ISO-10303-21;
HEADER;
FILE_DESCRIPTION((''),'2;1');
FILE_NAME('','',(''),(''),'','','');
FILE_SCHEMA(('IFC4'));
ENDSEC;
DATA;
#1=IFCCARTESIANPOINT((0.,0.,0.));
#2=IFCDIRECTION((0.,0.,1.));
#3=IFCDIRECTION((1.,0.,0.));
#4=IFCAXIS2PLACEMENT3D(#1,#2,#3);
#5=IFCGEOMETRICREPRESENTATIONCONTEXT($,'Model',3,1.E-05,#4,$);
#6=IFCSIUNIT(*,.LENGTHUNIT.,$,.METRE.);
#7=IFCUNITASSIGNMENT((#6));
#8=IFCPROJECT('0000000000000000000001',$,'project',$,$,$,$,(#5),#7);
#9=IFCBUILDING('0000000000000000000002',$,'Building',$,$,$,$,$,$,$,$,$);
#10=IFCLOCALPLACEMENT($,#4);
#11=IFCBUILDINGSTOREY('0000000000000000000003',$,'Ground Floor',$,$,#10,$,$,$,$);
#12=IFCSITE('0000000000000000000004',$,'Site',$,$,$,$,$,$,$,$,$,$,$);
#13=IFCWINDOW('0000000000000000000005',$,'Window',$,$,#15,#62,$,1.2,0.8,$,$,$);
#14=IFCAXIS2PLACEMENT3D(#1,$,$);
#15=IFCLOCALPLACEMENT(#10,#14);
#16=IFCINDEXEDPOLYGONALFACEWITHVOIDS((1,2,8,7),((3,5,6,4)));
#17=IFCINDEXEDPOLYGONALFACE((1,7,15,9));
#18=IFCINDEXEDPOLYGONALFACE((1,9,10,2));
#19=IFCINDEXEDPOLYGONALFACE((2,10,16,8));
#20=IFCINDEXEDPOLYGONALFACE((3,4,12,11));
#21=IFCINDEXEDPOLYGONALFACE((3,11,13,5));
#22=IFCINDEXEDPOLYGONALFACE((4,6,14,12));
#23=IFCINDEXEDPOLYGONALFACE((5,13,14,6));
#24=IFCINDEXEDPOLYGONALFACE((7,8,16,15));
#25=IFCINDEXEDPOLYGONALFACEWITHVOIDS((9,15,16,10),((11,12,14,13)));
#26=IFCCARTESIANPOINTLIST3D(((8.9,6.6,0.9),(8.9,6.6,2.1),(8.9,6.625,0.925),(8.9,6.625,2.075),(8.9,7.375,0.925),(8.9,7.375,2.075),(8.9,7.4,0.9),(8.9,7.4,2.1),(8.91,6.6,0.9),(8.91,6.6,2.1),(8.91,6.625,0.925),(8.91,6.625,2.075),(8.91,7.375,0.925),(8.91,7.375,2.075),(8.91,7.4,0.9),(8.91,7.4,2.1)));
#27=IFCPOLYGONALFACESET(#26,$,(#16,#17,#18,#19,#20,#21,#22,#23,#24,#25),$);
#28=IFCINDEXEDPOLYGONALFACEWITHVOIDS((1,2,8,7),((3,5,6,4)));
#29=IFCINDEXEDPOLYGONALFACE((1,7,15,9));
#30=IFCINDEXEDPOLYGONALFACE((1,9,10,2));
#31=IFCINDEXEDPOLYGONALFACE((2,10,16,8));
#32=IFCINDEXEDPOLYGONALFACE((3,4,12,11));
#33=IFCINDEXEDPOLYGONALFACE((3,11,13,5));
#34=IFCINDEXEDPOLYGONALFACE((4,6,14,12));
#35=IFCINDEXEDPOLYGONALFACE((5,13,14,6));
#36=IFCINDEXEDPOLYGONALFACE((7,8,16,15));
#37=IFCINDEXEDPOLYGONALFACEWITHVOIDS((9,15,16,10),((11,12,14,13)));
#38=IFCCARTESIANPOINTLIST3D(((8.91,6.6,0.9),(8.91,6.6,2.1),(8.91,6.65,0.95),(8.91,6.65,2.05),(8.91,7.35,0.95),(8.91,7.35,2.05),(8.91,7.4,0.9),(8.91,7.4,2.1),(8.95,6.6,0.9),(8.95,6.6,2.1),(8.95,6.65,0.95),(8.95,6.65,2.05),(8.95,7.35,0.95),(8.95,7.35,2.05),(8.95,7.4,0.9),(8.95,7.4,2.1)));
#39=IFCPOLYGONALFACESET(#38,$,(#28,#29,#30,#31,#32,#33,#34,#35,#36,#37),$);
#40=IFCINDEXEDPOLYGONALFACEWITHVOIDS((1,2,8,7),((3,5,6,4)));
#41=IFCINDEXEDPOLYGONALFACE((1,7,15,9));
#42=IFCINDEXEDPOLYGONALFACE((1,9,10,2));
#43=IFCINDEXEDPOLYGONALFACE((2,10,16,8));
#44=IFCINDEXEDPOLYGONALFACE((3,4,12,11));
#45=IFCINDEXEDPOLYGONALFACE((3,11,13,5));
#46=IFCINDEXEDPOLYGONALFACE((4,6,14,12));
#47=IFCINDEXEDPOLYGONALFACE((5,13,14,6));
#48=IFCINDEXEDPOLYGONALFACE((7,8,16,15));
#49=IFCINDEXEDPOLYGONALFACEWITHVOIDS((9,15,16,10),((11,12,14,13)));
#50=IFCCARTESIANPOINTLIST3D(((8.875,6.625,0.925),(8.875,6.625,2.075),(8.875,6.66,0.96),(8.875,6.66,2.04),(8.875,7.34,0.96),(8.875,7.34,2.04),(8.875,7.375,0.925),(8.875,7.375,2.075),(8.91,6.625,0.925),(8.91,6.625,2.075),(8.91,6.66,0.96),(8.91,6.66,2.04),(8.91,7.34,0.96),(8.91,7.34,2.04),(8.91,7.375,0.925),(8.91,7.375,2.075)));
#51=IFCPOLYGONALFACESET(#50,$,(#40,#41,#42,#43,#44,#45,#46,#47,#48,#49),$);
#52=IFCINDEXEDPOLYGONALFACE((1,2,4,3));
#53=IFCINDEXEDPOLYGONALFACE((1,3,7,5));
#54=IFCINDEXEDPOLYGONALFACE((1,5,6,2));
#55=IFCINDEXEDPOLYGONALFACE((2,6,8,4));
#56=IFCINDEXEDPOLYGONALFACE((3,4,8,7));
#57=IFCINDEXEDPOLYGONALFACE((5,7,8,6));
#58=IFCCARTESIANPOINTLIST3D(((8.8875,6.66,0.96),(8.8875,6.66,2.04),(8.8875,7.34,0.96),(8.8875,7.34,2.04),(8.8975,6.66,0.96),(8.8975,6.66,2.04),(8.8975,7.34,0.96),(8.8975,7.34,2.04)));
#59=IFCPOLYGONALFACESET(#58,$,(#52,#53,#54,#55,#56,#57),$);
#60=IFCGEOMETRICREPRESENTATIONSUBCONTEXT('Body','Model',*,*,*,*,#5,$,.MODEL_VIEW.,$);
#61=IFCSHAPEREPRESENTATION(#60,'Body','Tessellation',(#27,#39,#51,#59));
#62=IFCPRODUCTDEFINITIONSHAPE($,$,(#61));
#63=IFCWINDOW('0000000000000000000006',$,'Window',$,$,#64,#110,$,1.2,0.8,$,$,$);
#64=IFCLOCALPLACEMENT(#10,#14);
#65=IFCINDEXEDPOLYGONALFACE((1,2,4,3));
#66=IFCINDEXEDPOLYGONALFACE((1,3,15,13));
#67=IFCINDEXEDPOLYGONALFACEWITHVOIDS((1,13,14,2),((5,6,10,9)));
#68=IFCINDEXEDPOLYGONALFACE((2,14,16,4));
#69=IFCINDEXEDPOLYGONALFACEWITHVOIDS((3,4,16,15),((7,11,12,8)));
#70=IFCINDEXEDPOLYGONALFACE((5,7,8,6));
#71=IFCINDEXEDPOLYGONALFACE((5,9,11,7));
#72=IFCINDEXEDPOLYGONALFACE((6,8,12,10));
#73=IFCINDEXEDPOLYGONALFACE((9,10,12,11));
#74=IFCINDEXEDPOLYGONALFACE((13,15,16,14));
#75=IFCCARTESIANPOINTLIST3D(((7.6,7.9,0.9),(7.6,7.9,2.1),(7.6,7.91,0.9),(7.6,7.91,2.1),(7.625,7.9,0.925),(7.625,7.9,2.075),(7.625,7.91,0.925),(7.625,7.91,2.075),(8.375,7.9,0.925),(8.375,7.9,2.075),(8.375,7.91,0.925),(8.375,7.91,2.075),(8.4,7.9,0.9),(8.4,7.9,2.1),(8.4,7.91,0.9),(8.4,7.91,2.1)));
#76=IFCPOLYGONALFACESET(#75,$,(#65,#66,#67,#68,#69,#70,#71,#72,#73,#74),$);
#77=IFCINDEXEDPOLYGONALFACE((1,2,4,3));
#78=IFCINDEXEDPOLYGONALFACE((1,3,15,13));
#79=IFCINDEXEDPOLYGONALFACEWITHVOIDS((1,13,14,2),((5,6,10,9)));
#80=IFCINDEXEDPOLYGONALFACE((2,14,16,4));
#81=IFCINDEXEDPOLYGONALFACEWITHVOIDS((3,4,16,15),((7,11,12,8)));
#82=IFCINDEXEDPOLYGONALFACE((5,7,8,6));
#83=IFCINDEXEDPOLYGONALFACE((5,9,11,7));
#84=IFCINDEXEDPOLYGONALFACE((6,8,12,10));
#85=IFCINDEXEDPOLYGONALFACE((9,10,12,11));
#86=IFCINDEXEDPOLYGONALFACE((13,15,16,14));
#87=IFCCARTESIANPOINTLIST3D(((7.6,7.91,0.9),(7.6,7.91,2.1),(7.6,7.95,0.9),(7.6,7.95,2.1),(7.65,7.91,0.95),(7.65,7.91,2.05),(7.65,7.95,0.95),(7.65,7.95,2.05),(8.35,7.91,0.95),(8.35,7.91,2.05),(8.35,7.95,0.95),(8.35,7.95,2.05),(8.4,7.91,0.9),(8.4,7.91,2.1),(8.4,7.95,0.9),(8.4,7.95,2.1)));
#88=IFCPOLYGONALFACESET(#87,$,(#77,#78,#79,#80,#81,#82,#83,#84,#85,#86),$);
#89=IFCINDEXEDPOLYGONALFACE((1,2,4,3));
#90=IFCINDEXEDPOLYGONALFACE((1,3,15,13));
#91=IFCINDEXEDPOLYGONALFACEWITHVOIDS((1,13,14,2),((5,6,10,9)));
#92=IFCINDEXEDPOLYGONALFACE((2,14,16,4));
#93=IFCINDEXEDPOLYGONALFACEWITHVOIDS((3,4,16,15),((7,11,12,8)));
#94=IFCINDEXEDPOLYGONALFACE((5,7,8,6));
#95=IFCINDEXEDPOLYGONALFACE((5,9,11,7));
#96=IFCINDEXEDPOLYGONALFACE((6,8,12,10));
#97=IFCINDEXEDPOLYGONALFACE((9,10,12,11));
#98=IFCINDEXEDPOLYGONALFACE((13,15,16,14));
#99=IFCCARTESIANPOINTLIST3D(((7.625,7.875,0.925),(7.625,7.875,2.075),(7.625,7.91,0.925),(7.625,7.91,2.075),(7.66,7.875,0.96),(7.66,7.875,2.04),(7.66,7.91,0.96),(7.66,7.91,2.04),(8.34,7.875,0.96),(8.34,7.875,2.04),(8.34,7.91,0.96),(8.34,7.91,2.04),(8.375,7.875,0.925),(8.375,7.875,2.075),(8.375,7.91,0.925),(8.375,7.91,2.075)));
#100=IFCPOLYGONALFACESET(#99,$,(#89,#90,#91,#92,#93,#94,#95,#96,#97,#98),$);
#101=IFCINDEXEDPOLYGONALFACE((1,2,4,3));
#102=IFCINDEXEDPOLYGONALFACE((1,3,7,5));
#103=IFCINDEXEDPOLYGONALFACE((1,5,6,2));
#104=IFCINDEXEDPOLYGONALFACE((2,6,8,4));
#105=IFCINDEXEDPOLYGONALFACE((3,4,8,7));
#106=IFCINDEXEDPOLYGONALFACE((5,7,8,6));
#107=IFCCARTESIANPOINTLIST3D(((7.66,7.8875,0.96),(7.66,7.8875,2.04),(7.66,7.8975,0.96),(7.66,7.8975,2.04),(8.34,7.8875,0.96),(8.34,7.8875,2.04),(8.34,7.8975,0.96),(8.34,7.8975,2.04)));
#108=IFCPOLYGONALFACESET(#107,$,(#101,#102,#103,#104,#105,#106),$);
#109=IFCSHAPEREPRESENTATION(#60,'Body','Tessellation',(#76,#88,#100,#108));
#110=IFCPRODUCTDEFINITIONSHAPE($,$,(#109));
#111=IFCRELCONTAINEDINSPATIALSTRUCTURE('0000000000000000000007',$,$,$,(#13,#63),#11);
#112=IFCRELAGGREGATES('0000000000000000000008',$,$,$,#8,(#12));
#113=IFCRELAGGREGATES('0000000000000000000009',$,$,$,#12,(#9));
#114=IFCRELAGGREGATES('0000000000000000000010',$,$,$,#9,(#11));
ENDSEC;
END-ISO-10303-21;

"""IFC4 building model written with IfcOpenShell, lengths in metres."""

from ifc_helpers import new_model, si_unit, frame, origin_with_axes, place, context, subcontext, project, spatial, line, indexed_curve, outline, extrude, element, save


model = new_model("IFC4")

# Units and contexts
model_context = context("Model", 3, precision=1e-05, world=origin_with_axes())
body_context = subcontext(model_context, "Body", "Model", "MODEL_VIEW")
ifc_project = project(units=[si_unit("LENGTHUNIT", "METRE")], contexts=[model_context])

# Site, building, storey
site = spatial("IfcSite", under=ifc_project, Name="Site")
building = spatial("IfcBuilding", under=site, Name="Building")
storey_placement = place(None, origin_with_axes())
storey = spatial("IfcBuildingStorey", under=building, at=storey_placement, Name="Ground Floor")

# Windows
for number, where, z_axis, x_axis, name in (
    (1, (9.0, 6.6, 0.9), (0.0, 0.0, 1.0), (0.0, 1.0, 0.0), "Window"),
    (2, (8.4, 8.0, 0.9), (0.0, 0.0, 1.0), (-1.0, 0.0, 0.0), "Window"),
):
    element("IfcWindow", number, at=place(storey_placement, frame(where, z_axis=z_axis, x_axis=x_axis)), inside=storey, Name=name, OverallHeight=1.2, OverallWidth=0.8, context=body_context, shape_type="SweptSolid", body=[
        extrude(outline(indexed_curve([(0.0, 0.0), (0.8, 0.0), (0.8, 1.2), (0.0, 1.2)], segments=[line(1, 2, 3, 4, 1)]), holes=[indexed_curve([(0.025, 0.025), (0.775, 0.025), (0.775, 1.175), (0.025, 1.175)], segments=[line(1, 2, 3, 4, 1)])]), frame((0.0, 0.09, 0.0), z_axis=(0.0, -1.0, 0.0), x_axis=(1.0, 0.0, 0.0)), (0.0, 0.0, -1.0), 0.01),
        extrude(outline(indexed_curve([(0.0, 0.0), (0.8, 0.0), (0.8, 1.2), (0.0, 1.2)], segments=[line(1, 2, 3, 4, 1)]), holes=[indexed_curve([(0.05, 0.05), (0.75, 0.05), (0.75, 1.15), (0.05, 1.15)], segments=[line(1, 2, 3, 4, 1)])]), frame((0.0, 0.05, 0.0), z_axis=(0.0, -1.0, 0.0), x_axis=(1.0, 0.0, 0.0)), (0.0, 0.0, -1.0), 0.04),
        extrude(outline(indexed_curve([(0.0, 0.0), (0.75, 0.0), (0.75, 1.15), (0.0, 1.15)], segments=[line(1, 2, 3, 4, 1)]), holes=[indexed_curve([(0.035, 0.035), (0.715, 0.035), (0.715, 1.115), (0.035, 1.115)], segments=[line(1, 2, 3, 4, 1)])]), frame((0.025, 0.09, 0.025), z_axis=(0.0, -1.0, 0.0), x_axis=(1.0, 0.0, 0.0)), (0.0, 0.0, -1.0), 0.035),
        extrude(outline(indexed_curve([(0.035, 0.035), (0.715, 0.035), (0.715, 1.115), (0.035, 1.115)], segments=[line(1, 2, 3, 4, 1)])), frame((0.025, 0.1025, 0.025), z_axis=(0.0, -1.0, 0.0), x_axis=(1.0, 0.0, 0.0)), (0.0, 0.0, -1.0), 0.01),
    ])

save(model, "model.ifc")
